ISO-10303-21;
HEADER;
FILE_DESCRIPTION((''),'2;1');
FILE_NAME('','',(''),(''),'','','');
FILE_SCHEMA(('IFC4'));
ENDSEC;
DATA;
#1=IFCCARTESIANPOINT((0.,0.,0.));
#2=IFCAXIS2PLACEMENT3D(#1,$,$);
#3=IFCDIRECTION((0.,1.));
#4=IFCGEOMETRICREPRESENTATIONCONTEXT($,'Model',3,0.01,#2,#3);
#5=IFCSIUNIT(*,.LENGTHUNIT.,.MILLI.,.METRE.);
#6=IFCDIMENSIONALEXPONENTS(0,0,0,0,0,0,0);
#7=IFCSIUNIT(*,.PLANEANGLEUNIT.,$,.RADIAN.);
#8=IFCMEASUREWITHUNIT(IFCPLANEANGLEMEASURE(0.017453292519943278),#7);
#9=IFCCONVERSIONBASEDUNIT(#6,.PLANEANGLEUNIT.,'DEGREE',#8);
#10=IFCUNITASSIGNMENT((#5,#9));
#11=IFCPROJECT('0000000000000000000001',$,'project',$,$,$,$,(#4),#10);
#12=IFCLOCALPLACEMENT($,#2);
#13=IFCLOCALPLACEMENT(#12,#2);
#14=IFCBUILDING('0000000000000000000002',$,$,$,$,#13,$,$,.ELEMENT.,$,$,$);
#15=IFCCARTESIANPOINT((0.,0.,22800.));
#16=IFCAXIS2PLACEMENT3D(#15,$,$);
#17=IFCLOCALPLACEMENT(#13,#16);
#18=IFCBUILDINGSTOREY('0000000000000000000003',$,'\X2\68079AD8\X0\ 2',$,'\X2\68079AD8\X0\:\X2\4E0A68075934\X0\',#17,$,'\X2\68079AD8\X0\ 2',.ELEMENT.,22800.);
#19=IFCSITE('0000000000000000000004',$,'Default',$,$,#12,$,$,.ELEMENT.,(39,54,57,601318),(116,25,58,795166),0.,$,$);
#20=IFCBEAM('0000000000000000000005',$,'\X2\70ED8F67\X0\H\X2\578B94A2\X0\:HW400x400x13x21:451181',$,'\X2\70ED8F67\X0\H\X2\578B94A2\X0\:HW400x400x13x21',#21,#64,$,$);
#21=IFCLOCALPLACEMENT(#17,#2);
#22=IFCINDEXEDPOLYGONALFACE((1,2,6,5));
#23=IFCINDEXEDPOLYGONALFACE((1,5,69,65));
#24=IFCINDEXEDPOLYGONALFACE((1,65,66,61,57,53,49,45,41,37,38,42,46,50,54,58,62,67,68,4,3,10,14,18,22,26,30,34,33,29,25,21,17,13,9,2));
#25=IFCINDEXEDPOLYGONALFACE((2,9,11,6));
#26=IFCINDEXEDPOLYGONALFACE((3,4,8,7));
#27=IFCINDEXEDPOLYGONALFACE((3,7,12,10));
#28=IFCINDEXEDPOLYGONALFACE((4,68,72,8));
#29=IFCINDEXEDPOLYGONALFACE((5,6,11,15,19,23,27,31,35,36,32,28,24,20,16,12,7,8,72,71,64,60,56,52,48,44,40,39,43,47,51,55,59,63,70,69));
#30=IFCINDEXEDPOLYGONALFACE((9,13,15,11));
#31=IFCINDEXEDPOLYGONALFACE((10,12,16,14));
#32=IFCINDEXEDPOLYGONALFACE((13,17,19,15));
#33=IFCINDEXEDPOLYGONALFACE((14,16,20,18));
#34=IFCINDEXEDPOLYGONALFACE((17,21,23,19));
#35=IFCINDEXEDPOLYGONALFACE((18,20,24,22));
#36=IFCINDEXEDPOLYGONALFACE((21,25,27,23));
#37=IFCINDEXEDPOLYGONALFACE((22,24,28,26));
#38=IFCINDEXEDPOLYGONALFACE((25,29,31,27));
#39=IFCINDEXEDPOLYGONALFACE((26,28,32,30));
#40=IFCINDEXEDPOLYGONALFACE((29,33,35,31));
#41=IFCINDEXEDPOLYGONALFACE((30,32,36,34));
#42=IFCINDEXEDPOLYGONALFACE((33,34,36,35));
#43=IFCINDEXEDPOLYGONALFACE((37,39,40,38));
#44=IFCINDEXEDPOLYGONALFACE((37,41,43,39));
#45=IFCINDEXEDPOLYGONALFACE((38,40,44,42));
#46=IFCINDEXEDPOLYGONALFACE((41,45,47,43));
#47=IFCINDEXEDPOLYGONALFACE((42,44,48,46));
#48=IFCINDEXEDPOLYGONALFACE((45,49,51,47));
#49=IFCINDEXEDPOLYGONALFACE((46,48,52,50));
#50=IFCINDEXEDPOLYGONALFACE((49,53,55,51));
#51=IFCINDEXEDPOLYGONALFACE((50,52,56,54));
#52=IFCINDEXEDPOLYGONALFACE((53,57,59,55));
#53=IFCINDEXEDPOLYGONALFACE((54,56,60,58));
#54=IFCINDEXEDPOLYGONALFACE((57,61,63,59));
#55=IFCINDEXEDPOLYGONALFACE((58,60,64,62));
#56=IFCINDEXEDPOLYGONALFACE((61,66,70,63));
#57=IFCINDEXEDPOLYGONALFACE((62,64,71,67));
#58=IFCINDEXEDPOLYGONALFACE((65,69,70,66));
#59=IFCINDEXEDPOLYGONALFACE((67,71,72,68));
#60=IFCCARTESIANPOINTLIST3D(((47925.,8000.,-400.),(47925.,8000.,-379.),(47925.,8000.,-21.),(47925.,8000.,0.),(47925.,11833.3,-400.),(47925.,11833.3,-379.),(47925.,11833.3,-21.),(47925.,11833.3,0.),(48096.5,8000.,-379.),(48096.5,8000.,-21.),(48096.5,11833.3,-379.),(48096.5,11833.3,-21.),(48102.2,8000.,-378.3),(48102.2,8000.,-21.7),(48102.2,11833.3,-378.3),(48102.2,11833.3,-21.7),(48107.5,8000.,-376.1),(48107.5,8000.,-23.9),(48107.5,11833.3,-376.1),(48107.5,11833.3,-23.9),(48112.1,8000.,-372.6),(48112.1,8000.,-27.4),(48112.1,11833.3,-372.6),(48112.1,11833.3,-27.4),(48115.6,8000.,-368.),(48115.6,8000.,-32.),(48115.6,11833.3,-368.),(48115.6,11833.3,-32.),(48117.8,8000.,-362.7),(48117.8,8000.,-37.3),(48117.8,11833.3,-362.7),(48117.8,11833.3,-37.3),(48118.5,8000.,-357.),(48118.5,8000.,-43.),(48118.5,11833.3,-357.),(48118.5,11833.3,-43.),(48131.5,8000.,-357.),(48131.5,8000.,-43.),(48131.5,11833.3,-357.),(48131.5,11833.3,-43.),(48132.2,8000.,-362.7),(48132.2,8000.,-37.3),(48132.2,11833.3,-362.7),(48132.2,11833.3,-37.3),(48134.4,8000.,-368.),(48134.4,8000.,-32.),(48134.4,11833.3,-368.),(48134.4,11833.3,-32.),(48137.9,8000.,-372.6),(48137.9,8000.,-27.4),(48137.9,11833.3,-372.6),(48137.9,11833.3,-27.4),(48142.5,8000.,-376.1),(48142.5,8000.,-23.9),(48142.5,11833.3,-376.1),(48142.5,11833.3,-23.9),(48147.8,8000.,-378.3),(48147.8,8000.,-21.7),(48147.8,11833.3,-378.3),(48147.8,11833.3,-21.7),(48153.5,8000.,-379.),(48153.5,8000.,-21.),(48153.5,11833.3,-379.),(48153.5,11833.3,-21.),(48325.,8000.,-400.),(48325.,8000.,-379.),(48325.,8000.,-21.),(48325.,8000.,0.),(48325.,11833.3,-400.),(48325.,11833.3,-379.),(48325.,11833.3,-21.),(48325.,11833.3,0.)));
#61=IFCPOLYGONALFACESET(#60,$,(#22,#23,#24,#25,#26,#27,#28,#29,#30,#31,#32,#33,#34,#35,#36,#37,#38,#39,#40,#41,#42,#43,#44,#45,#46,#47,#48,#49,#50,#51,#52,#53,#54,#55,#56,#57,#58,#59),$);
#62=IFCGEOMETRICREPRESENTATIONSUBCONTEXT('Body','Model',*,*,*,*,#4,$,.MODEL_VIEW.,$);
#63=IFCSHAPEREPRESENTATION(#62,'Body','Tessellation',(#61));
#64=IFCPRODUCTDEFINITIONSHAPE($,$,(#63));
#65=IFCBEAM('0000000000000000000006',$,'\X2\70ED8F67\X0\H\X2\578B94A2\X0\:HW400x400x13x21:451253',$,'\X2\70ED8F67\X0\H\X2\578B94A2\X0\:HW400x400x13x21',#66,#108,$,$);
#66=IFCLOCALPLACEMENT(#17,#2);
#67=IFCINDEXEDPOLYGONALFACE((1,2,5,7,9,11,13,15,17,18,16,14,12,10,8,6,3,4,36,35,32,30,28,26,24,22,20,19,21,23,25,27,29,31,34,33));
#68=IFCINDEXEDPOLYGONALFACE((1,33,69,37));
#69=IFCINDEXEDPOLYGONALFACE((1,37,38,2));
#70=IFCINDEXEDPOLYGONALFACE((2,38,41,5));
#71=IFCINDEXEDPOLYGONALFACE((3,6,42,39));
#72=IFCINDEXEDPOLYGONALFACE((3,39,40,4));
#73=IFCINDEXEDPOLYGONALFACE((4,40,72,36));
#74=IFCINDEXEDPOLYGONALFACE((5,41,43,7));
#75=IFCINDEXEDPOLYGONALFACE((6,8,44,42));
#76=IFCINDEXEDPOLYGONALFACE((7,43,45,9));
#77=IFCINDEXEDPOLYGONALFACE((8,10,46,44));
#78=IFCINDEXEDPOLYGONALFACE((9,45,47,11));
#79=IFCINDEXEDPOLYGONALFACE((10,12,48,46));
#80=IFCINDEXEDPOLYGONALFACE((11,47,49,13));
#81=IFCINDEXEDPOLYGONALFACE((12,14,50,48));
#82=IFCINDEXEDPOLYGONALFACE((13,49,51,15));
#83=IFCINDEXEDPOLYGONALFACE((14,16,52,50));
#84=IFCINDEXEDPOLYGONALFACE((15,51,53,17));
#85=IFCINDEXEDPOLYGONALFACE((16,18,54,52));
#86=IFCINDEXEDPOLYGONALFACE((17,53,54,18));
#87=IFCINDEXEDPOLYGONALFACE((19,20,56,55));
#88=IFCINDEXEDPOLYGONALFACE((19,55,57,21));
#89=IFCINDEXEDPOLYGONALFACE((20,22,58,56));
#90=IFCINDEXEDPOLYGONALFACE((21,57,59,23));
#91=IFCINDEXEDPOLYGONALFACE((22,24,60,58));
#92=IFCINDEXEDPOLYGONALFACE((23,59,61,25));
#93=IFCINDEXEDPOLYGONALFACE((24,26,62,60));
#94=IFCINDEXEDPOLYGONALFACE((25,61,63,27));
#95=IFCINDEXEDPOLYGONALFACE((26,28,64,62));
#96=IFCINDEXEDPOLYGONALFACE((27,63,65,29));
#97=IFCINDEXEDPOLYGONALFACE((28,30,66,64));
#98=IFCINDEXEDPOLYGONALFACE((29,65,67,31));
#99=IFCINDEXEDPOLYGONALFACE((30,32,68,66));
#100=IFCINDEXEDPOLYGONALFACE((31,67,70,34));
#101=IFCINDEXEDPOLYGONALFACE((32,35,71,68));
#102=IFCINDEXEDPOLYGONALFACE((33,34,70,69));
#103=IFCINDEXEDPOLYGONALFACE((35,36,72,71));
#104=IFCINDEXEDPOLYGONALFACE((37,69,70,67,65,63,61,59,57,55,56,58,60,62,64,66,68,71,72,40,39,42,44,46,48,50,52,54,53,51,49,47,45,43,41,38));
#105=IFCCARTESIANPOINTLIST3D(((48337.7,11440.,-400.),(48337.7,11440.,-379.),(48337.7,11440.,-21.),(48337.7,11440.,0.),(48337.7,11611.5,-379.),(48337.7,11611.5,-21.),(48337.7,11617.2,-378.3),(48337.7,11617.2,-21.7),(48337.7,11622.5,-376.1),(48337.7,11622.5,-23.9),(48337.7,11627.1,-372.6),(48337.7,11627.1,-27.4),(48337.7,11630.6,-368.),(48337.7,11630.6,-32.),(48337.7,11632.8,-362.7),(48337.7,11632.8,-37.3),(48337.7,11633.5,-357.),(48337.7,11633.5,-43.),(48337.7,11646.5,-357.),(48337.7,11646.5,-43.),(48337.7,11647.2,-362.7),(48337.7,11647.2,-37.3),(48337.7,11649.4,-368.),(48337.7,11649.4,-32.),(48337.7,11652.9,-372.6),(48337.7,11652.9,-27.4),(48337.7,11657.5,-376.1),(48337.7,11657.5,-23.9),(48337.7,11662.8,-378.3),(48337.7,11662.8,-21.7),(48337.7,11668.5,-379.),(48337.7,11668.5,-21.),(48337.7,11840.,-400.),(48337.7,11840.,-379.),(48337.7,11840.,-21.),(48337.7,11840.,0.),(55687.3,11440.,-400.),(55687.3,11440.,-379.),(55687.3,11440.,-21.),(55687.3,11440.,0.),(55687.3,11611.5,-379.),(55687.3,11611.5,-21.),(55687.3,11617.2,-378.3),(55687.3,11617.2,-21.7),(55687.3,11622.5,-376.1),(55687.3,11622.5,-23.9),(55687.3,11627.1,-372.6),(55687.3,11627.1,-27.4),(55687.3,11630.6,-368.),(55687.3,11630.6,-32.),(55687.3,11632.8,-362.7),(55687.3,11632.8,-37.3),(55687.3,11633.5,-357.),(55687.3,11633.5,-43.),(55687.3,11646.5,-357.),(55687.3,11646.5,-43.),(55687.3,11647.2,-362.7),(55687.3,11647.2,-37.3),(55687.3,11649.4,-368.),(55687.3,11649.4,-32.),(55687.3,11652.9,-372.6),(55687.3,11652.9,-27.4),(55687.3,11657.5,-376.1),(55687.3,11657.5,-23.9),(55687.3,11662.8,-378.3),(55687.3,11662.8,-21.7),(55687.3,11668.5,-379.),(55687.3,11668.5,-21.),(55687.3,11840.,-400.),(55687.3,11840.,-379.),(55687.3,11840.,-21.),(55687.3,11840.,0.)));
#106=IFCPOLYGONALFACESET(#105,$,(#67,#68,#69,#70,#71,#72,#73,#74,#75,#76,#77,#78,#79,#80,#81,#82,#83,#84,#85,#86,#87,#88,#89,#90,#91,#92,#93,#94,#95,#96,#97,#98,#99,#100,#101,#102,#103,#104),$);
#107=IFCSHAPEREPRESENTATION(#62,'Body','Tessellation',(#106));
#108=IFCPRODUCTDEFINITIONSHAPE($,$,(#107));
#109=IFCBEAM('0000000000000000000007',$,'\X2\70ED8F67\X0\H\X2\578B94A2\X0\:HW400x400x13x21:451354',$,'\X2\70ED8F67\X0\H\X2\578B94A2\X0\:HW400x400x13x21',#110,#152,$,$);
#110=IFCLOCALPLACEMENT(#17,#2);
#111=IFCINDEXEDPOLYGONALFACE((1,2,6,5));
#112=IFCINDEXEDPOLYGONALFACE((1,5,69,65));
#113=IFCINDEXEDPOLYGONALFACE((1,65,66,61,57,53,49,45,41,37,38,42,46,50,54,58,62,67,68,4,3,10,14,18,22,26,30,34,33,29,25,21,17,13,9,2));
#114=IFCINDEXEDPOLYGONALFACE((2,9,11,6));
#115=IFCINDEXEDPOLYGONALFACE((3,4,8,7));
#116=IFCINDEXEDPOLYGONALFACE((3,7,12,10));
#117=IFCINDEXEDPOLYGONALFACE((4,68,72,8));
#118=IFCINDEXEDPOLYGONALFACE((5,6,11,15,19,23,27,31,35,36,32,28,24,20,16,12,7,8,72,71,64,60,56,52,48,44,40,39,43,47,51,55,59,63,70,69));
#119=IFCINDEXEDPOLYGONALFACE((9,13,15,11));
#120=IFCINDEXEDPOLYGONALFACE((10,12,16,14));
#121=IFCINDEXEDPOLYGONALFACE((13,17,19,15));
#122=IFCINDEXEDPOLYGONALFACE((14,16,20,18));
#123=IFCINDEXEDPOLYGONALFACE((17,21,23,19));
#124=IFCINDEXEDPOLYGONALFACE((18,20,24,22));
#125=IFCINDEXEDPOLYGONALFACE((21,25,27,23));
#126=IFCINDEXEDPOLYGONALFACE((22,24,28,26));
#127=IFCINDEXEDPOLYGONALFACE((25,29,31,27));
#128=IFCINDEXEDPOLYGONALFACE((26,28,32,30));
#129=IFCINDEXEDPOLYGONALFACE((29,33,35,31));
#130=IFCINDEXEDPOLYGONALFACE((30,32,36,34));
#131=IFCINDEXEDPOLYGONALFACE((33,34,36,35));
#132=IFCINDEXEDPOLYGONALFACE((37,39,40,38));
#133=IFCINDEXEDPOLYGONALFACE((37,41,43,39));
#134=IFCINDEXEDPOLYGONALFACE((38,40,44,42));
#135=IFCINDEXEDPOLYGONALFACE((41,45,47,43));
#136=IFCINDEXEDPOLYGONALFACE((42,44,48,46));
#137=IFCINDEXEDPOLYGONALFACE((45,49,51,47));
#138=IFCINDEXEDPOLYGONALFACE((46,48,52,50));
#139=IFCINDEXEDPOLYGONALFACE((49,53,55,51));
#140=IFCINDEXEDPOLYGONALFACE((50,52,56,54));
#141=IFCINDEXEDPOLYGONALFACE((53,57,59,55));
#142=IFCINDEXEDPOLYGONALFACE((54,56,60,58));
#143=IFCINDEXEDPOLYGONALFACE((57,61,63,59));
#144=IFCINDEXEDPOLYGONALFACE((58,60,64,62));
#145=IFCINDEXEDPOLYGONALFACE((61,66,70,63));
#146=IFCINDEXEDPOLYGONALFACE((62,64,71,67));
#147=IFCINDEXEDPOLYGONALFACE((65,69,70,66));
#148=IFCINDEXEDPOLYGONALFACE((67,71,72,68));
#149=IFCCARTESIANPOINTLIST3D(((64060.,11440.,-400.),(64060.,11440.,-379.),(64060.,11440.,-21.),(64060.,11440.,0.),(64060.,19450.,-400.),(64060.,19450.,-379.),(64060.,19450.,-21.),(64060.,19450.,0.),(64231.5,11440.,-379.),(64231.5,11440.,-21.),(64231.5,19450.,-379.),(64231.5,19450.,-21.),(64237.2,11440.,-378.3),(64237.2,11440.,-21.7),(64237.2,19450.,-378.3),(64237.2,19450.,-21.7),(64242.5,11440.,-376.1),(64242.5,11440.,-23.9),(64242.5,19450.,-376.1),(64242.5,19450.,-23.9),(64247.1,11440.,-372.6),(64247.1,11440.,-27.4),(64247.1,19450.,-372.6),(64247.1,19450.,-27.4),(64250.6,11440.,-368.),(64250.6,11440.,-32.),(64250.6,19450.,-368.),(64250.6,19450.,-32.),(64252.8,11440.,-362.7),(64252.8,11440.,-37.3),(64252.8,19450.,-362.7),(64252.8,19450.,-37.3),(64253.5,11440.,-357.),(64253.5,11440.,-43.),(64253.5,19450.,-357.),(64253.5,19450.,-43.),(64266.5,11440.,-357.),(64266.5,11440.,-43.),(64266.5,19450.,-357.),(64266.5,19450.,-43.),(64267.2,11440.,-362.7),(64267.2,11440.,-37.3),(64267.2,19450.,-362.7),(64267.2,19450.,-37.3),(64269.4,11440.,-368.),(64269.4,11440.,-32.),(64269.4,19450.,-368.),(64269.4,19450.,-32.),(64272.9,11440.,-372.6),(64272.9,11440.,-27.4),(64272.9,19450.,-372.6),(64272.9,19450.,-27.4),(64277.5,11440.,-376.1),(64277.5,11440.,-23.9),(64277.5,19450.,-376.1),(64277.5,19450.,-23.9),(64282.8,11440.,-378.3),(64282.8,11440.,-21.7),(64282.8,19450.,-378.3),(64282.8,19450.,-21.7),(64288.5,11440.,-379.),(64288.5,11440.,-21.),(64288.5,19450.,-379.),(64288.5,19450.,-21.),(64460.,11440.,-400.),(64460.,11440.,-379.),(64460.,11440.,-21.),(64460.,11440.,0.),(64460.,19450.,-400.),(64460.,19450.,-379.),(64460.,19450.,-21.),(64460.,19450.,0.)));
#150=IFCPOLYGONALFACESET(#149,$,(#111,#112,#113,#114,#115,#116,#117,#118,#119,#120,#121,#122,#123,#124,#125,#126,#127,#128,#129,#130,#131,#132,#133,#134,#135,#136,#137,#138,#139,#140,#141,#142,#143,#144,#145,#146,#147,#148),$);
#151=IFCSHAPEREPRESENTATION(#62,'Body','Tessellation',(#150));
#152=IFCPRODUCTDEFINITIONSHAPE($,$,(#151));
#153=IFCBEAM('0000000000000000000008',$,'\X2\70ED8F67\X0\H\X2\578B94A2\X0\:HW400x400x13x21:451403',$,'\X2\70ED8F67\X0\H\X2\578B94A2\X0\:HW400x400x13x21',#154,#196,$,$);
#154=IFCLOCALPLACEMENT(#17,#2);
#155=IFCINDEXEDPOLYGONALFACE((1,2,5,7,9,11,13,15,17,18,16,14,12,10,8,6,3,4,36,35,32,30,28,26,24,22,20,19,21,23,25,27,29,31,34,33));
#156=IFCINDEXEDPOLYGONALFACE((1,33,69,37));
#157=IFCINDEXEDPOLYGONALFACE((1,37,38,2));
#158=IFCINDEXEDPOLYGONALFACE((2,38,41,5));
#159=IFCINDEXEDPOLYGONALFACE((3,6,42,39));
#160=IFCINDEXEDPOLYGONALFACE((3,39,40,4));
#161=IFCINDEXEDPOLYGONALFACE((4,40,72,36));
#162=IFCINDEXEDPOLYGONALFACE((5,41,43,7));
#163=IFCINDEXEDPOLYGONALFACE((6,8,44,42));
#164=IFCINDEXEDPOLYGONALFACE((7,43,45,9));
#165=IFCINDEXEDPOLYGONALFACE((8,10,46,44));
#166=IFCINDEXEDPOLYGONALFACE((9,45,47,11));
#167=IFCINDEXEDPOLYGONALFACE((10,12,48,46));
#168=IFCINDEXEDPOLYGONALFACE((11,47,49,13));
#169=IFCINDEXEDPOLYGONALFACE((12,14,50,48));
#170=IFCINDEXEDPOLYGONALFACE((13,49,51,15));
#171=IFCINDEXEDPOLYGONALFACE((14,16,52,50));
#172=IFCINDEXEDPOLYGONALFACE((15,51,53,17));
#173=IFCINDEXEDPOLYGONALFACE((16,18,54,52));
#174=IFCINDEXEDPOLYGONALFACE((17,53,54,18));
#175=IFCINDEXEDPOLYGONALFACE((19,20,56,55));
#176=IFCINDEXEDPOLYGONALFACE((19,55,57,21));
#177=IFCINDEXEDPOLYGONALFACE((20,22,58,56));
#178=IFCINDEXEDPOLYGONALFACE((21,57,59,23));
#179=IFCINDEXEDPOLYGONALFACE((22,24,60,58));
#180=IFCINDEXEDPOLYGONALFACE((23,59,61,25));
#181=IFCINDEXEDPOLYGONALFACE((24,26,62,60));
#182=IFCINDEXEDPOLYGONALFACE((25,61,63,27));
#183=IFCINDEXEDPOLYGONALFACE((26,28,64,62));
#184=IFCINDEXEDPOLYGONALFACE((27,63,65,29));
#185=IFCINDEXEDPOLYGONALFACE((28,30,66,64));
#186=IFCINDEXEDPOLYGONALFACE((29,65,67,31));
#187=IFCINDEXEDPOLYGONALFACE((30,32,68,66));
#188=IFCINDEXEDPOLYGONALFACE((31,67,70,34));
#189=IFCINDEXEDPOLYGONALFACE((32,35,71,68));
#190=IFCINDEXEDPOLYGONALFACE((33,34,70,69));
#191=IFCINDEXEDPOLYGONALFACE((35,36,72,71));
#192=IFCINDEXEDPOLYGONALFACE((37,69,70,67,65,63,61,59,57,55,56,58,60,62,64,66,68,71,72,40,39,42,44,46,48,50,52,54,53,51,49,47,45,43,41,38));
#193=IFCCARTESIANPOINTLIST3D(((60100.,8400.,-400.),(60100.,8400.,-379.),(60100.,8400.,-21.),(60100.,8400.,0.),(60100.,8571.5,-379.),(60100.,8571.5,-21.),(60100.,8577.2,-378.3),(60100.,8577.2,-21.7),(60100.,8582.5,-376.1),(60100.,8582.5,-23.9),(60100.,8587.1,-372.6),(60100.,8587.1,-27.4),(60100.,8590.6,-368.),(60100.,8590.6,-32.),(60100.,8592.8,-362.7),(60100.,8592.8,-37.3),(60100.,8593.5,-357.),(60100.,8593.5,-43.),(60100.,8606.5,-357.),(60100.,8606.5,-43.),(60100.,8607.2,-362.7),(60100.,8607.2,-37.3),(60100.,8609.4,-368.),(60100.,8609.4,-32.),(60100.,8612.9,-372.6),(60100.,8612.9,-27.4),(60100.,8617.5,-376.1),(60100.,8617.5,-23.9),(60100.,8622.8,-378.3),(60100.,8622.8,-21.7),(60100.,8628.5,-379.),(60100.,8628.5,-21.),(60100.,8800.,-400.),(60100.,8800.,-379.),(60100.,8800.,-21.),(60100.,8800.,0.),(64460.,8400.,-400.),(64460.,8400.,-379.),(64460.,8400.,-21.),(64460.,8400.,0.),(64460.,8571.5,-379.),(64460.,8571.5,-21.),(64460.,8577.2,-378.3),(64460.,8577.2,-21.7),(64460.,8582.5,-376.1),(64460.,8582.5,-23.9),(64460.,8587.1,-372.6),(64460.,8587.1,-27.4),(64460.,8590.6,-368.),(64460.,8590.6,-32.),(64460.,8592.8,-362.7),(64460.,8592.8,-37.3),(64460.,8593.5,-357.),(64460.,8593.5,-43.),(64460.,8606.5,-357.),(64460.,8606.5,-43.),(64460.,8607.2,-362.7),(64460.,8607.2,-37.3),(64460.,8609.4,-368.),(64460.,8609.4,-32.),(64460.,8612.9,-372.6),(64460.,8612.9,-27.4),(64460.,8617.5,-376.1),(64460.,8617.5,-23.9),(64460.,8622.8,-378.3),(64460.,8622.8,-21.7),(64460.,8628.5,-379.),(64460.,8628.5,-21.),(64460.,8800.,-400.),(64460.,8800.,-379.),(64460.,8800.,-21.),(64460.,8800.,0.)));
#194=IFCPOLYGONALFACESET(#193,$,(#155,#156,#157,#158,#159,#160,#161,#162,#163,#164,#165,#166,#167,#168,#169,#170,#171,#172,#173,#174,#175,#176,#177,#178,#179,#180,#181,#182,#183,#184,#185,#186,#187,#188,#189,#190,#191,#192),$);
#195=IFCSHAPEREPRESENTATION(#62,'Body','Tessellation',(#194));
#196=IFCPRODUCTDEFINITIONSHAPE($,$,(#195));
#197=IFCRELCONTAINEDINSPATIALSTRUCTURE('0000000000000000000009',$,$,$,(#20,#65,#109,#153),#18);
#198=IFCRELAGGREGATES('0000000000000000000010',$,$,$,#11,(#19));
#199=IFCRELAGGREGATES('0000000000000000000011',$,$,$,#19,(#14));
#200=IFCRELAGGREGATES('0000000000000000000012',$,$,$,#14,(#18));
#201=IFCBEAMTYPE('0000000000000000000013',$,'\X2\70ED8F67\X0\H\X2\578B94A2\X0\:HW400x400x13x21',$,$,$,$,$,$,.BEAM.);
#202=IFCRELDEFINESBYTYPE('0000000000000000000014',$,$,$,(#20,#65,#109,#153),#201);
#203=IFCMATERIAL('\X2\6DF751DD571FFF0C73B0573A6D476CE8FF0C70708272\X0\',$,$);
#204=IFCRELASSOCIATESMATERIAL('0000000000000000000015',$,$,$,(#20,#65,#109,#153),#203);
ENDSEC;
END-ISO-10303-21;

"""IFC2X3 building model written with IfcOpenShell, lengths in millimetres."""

from ifc_helpers import new_model, entity, si_unit, converted_unit, direction, frame, frame_2d, origin, place, context, subcontext, project, spatial, i_section, extrude, material, type_object, element, save


model = new_model("IFC2X3")

# Units and contexts
model_context = context("Model", 3, precision=0.01, world=origin(), true_north=direction((0.0, 1.0)))
body_context = subcontext(model_context, "Body", "Model", "MODEL_VIEW")
ifc_project = project(units=[si_unit("LENGTHUNIT", "METRE", prefix="MILLI"), converted_unit("PLANEANGLEUNIT", "DEGREE", entity("IfcPlaneAngleMeasure", 0.017453292519943278), si_unit("PLANEANGLEUNIT", "RADIAN"), dimensions=[0, 0, 0, 0, 0, 0, 0])], contexts=[model_context])

# Site, building, storey
site_placement = place(None, origin())
site = spatial("IfcSite", under=ifc_project, at=site_placement, Name="Default", CompositionType="ELEMENT", RefLatitude=(39, 54, 57, 601318), RefLongitude=(116, 25, 58, 795166), RefElevation=0.0)
building_placement = place(site_placement, origin())
building = spatial("IfcBuilding", under=site, at=building_placement, CompositionType="ELEMENT")
storey_placement = place(building_placement, frame((0.0, 0.0, 22800.0)))
storey = spatial("IfcBuildingStorey", under=building, at=storey_placement, Name="标高 2", ObjectType="标高:上标头", LongName="标高 2", CompositionType="ELEMENT", Elevation=22800.0)

# Beams
ifc_material = material(Name="混凝土，现场浇注，灰色")
beam_type = type_object("IfcBeamType", Name="热轧H型钢:HW400x400x13x21", PredefinedType="BEAM")
beam_1_placement = place(storey_placement, frame((48125.0, 11840.0, 0.0), z_axis=(0.0, 0.0, 1.0), x_axis=(0.0, -1.0, 0.0)))
element("IfcBeam", 1, at=beam_1_placement, inside=storey, type_object=beam_type, material=ifc_material, Name="热轧H型钢:HW400x400x13x21:451181", ObjectType="热轧H型钢:HW400x400x13x21", context=body_context, shape_type="SweptSolid", body=[
    extrude(i_section(OverallWidth=400.0, OverallDepth=400.0, WebThickness=13.0, FlangeThickness=21.0, FilletRadius=22.0, at=frame_2d((0.0, 0.0), x_axis=(0.0, 1.0))), frame((6.7, 0.0, -200.0), z_axis=(1.0, 0.0, 0.0), x_axis=(0.0, 0.0, -1.0)), (0.0, 0.0, 1.0), 3833.3),
])
beam_2_placement = place(storey_placement, frame((48125.0, 11640.0, 0.0)))
element("IfcBeam", 2, at=beam_2_placement, inside=storey, type_object=beam_type, material=ifc_material, Name="热轧H型钢:HW400x400x13x21:451253", ObjectType="热轧H型钢:HW400x400x13x21", context=body_context, shape_type="SweptSolid", body=[
    extrude(i_section(OverallWidth=400.0, OverallDepth=400.0, WebThickness=13.0, FlangeThickness=21.0, FilletRadius=22.0, at=frame_2d((0.0, 0.0), x_axis=(0.0, 1.0))), frame((212.7, 0.0, -200.0), z_axis=(1.0, 0.0, 0.0), x_axis=(0.0, 0.0, -1.0)), (0.0, 0.0, 1.0), 7349.6),
])
beam_3_placement = place(storey_placement, frame((64260.0, 11640.0, 0.0), z_axis=(0.0, 0.0, 1.0), x_axis=(0.0, 1.0, 0.0)))
element("IfcBeam", 3, at=beam_3_placement, inside=storey, type_object=beam_type, material=ifc_material, Name="热轧H型钢:HW400x400x13x21:451354", ObjectType="热轧H型钢:HW400x400x13x21", context=body_context, shape_type="SweptSolid", body=[
    extrude(i_section(OverallWidth=400.0, OverallDepth=400.0, WebThickness=13.0, FlangeThickness=21.0, FilletRadius=22.0, at=frame_2d((0.0, 0.0), x_axis=(0.0, 1.0))), frame((-200.0, 0.0, -200.0), z_axis=(1.0, 0.0, 0.0), x_axis=(0.0, 0.0, -1.0)), (0.0, 0.0, 1.0), 8010.0),
])
beam_4_placement = place(storey_placement, frame((64260.0, 8600.0, 0.0), z_axis=(0.0, 0.0, 1.0), x_axis=(-1.0, 0.0, 0.0)))
element("IfcBeam", 4, at=beam_4_placement, inside=storey, type_object=beam_type, material=ifc_material, Name="热轧H型钢:HW400x400x13x21:451403", ObjectType="热轧H型钢:HW400x400x13x21", context=body_context, shape_type="SweptSolid", body=[
    extrude(i_section(OverallWidth=400.0, OverallDepth=400.0, WebThickness=13.0, FlangeThickness=21.0, FilletRadius=22.0, at=frame_2d((0.0, 0.0), x_axis=(0.0, 1.0))), frame((-200.0, 0.0, -200.0), z_axis=(1.0, 0.0, 0.0), x_axis=(0.0, 0.0, -1.0)), (0.0, 0.0, 1.0), 4360.0),
])

save(model, "model.ifc")
